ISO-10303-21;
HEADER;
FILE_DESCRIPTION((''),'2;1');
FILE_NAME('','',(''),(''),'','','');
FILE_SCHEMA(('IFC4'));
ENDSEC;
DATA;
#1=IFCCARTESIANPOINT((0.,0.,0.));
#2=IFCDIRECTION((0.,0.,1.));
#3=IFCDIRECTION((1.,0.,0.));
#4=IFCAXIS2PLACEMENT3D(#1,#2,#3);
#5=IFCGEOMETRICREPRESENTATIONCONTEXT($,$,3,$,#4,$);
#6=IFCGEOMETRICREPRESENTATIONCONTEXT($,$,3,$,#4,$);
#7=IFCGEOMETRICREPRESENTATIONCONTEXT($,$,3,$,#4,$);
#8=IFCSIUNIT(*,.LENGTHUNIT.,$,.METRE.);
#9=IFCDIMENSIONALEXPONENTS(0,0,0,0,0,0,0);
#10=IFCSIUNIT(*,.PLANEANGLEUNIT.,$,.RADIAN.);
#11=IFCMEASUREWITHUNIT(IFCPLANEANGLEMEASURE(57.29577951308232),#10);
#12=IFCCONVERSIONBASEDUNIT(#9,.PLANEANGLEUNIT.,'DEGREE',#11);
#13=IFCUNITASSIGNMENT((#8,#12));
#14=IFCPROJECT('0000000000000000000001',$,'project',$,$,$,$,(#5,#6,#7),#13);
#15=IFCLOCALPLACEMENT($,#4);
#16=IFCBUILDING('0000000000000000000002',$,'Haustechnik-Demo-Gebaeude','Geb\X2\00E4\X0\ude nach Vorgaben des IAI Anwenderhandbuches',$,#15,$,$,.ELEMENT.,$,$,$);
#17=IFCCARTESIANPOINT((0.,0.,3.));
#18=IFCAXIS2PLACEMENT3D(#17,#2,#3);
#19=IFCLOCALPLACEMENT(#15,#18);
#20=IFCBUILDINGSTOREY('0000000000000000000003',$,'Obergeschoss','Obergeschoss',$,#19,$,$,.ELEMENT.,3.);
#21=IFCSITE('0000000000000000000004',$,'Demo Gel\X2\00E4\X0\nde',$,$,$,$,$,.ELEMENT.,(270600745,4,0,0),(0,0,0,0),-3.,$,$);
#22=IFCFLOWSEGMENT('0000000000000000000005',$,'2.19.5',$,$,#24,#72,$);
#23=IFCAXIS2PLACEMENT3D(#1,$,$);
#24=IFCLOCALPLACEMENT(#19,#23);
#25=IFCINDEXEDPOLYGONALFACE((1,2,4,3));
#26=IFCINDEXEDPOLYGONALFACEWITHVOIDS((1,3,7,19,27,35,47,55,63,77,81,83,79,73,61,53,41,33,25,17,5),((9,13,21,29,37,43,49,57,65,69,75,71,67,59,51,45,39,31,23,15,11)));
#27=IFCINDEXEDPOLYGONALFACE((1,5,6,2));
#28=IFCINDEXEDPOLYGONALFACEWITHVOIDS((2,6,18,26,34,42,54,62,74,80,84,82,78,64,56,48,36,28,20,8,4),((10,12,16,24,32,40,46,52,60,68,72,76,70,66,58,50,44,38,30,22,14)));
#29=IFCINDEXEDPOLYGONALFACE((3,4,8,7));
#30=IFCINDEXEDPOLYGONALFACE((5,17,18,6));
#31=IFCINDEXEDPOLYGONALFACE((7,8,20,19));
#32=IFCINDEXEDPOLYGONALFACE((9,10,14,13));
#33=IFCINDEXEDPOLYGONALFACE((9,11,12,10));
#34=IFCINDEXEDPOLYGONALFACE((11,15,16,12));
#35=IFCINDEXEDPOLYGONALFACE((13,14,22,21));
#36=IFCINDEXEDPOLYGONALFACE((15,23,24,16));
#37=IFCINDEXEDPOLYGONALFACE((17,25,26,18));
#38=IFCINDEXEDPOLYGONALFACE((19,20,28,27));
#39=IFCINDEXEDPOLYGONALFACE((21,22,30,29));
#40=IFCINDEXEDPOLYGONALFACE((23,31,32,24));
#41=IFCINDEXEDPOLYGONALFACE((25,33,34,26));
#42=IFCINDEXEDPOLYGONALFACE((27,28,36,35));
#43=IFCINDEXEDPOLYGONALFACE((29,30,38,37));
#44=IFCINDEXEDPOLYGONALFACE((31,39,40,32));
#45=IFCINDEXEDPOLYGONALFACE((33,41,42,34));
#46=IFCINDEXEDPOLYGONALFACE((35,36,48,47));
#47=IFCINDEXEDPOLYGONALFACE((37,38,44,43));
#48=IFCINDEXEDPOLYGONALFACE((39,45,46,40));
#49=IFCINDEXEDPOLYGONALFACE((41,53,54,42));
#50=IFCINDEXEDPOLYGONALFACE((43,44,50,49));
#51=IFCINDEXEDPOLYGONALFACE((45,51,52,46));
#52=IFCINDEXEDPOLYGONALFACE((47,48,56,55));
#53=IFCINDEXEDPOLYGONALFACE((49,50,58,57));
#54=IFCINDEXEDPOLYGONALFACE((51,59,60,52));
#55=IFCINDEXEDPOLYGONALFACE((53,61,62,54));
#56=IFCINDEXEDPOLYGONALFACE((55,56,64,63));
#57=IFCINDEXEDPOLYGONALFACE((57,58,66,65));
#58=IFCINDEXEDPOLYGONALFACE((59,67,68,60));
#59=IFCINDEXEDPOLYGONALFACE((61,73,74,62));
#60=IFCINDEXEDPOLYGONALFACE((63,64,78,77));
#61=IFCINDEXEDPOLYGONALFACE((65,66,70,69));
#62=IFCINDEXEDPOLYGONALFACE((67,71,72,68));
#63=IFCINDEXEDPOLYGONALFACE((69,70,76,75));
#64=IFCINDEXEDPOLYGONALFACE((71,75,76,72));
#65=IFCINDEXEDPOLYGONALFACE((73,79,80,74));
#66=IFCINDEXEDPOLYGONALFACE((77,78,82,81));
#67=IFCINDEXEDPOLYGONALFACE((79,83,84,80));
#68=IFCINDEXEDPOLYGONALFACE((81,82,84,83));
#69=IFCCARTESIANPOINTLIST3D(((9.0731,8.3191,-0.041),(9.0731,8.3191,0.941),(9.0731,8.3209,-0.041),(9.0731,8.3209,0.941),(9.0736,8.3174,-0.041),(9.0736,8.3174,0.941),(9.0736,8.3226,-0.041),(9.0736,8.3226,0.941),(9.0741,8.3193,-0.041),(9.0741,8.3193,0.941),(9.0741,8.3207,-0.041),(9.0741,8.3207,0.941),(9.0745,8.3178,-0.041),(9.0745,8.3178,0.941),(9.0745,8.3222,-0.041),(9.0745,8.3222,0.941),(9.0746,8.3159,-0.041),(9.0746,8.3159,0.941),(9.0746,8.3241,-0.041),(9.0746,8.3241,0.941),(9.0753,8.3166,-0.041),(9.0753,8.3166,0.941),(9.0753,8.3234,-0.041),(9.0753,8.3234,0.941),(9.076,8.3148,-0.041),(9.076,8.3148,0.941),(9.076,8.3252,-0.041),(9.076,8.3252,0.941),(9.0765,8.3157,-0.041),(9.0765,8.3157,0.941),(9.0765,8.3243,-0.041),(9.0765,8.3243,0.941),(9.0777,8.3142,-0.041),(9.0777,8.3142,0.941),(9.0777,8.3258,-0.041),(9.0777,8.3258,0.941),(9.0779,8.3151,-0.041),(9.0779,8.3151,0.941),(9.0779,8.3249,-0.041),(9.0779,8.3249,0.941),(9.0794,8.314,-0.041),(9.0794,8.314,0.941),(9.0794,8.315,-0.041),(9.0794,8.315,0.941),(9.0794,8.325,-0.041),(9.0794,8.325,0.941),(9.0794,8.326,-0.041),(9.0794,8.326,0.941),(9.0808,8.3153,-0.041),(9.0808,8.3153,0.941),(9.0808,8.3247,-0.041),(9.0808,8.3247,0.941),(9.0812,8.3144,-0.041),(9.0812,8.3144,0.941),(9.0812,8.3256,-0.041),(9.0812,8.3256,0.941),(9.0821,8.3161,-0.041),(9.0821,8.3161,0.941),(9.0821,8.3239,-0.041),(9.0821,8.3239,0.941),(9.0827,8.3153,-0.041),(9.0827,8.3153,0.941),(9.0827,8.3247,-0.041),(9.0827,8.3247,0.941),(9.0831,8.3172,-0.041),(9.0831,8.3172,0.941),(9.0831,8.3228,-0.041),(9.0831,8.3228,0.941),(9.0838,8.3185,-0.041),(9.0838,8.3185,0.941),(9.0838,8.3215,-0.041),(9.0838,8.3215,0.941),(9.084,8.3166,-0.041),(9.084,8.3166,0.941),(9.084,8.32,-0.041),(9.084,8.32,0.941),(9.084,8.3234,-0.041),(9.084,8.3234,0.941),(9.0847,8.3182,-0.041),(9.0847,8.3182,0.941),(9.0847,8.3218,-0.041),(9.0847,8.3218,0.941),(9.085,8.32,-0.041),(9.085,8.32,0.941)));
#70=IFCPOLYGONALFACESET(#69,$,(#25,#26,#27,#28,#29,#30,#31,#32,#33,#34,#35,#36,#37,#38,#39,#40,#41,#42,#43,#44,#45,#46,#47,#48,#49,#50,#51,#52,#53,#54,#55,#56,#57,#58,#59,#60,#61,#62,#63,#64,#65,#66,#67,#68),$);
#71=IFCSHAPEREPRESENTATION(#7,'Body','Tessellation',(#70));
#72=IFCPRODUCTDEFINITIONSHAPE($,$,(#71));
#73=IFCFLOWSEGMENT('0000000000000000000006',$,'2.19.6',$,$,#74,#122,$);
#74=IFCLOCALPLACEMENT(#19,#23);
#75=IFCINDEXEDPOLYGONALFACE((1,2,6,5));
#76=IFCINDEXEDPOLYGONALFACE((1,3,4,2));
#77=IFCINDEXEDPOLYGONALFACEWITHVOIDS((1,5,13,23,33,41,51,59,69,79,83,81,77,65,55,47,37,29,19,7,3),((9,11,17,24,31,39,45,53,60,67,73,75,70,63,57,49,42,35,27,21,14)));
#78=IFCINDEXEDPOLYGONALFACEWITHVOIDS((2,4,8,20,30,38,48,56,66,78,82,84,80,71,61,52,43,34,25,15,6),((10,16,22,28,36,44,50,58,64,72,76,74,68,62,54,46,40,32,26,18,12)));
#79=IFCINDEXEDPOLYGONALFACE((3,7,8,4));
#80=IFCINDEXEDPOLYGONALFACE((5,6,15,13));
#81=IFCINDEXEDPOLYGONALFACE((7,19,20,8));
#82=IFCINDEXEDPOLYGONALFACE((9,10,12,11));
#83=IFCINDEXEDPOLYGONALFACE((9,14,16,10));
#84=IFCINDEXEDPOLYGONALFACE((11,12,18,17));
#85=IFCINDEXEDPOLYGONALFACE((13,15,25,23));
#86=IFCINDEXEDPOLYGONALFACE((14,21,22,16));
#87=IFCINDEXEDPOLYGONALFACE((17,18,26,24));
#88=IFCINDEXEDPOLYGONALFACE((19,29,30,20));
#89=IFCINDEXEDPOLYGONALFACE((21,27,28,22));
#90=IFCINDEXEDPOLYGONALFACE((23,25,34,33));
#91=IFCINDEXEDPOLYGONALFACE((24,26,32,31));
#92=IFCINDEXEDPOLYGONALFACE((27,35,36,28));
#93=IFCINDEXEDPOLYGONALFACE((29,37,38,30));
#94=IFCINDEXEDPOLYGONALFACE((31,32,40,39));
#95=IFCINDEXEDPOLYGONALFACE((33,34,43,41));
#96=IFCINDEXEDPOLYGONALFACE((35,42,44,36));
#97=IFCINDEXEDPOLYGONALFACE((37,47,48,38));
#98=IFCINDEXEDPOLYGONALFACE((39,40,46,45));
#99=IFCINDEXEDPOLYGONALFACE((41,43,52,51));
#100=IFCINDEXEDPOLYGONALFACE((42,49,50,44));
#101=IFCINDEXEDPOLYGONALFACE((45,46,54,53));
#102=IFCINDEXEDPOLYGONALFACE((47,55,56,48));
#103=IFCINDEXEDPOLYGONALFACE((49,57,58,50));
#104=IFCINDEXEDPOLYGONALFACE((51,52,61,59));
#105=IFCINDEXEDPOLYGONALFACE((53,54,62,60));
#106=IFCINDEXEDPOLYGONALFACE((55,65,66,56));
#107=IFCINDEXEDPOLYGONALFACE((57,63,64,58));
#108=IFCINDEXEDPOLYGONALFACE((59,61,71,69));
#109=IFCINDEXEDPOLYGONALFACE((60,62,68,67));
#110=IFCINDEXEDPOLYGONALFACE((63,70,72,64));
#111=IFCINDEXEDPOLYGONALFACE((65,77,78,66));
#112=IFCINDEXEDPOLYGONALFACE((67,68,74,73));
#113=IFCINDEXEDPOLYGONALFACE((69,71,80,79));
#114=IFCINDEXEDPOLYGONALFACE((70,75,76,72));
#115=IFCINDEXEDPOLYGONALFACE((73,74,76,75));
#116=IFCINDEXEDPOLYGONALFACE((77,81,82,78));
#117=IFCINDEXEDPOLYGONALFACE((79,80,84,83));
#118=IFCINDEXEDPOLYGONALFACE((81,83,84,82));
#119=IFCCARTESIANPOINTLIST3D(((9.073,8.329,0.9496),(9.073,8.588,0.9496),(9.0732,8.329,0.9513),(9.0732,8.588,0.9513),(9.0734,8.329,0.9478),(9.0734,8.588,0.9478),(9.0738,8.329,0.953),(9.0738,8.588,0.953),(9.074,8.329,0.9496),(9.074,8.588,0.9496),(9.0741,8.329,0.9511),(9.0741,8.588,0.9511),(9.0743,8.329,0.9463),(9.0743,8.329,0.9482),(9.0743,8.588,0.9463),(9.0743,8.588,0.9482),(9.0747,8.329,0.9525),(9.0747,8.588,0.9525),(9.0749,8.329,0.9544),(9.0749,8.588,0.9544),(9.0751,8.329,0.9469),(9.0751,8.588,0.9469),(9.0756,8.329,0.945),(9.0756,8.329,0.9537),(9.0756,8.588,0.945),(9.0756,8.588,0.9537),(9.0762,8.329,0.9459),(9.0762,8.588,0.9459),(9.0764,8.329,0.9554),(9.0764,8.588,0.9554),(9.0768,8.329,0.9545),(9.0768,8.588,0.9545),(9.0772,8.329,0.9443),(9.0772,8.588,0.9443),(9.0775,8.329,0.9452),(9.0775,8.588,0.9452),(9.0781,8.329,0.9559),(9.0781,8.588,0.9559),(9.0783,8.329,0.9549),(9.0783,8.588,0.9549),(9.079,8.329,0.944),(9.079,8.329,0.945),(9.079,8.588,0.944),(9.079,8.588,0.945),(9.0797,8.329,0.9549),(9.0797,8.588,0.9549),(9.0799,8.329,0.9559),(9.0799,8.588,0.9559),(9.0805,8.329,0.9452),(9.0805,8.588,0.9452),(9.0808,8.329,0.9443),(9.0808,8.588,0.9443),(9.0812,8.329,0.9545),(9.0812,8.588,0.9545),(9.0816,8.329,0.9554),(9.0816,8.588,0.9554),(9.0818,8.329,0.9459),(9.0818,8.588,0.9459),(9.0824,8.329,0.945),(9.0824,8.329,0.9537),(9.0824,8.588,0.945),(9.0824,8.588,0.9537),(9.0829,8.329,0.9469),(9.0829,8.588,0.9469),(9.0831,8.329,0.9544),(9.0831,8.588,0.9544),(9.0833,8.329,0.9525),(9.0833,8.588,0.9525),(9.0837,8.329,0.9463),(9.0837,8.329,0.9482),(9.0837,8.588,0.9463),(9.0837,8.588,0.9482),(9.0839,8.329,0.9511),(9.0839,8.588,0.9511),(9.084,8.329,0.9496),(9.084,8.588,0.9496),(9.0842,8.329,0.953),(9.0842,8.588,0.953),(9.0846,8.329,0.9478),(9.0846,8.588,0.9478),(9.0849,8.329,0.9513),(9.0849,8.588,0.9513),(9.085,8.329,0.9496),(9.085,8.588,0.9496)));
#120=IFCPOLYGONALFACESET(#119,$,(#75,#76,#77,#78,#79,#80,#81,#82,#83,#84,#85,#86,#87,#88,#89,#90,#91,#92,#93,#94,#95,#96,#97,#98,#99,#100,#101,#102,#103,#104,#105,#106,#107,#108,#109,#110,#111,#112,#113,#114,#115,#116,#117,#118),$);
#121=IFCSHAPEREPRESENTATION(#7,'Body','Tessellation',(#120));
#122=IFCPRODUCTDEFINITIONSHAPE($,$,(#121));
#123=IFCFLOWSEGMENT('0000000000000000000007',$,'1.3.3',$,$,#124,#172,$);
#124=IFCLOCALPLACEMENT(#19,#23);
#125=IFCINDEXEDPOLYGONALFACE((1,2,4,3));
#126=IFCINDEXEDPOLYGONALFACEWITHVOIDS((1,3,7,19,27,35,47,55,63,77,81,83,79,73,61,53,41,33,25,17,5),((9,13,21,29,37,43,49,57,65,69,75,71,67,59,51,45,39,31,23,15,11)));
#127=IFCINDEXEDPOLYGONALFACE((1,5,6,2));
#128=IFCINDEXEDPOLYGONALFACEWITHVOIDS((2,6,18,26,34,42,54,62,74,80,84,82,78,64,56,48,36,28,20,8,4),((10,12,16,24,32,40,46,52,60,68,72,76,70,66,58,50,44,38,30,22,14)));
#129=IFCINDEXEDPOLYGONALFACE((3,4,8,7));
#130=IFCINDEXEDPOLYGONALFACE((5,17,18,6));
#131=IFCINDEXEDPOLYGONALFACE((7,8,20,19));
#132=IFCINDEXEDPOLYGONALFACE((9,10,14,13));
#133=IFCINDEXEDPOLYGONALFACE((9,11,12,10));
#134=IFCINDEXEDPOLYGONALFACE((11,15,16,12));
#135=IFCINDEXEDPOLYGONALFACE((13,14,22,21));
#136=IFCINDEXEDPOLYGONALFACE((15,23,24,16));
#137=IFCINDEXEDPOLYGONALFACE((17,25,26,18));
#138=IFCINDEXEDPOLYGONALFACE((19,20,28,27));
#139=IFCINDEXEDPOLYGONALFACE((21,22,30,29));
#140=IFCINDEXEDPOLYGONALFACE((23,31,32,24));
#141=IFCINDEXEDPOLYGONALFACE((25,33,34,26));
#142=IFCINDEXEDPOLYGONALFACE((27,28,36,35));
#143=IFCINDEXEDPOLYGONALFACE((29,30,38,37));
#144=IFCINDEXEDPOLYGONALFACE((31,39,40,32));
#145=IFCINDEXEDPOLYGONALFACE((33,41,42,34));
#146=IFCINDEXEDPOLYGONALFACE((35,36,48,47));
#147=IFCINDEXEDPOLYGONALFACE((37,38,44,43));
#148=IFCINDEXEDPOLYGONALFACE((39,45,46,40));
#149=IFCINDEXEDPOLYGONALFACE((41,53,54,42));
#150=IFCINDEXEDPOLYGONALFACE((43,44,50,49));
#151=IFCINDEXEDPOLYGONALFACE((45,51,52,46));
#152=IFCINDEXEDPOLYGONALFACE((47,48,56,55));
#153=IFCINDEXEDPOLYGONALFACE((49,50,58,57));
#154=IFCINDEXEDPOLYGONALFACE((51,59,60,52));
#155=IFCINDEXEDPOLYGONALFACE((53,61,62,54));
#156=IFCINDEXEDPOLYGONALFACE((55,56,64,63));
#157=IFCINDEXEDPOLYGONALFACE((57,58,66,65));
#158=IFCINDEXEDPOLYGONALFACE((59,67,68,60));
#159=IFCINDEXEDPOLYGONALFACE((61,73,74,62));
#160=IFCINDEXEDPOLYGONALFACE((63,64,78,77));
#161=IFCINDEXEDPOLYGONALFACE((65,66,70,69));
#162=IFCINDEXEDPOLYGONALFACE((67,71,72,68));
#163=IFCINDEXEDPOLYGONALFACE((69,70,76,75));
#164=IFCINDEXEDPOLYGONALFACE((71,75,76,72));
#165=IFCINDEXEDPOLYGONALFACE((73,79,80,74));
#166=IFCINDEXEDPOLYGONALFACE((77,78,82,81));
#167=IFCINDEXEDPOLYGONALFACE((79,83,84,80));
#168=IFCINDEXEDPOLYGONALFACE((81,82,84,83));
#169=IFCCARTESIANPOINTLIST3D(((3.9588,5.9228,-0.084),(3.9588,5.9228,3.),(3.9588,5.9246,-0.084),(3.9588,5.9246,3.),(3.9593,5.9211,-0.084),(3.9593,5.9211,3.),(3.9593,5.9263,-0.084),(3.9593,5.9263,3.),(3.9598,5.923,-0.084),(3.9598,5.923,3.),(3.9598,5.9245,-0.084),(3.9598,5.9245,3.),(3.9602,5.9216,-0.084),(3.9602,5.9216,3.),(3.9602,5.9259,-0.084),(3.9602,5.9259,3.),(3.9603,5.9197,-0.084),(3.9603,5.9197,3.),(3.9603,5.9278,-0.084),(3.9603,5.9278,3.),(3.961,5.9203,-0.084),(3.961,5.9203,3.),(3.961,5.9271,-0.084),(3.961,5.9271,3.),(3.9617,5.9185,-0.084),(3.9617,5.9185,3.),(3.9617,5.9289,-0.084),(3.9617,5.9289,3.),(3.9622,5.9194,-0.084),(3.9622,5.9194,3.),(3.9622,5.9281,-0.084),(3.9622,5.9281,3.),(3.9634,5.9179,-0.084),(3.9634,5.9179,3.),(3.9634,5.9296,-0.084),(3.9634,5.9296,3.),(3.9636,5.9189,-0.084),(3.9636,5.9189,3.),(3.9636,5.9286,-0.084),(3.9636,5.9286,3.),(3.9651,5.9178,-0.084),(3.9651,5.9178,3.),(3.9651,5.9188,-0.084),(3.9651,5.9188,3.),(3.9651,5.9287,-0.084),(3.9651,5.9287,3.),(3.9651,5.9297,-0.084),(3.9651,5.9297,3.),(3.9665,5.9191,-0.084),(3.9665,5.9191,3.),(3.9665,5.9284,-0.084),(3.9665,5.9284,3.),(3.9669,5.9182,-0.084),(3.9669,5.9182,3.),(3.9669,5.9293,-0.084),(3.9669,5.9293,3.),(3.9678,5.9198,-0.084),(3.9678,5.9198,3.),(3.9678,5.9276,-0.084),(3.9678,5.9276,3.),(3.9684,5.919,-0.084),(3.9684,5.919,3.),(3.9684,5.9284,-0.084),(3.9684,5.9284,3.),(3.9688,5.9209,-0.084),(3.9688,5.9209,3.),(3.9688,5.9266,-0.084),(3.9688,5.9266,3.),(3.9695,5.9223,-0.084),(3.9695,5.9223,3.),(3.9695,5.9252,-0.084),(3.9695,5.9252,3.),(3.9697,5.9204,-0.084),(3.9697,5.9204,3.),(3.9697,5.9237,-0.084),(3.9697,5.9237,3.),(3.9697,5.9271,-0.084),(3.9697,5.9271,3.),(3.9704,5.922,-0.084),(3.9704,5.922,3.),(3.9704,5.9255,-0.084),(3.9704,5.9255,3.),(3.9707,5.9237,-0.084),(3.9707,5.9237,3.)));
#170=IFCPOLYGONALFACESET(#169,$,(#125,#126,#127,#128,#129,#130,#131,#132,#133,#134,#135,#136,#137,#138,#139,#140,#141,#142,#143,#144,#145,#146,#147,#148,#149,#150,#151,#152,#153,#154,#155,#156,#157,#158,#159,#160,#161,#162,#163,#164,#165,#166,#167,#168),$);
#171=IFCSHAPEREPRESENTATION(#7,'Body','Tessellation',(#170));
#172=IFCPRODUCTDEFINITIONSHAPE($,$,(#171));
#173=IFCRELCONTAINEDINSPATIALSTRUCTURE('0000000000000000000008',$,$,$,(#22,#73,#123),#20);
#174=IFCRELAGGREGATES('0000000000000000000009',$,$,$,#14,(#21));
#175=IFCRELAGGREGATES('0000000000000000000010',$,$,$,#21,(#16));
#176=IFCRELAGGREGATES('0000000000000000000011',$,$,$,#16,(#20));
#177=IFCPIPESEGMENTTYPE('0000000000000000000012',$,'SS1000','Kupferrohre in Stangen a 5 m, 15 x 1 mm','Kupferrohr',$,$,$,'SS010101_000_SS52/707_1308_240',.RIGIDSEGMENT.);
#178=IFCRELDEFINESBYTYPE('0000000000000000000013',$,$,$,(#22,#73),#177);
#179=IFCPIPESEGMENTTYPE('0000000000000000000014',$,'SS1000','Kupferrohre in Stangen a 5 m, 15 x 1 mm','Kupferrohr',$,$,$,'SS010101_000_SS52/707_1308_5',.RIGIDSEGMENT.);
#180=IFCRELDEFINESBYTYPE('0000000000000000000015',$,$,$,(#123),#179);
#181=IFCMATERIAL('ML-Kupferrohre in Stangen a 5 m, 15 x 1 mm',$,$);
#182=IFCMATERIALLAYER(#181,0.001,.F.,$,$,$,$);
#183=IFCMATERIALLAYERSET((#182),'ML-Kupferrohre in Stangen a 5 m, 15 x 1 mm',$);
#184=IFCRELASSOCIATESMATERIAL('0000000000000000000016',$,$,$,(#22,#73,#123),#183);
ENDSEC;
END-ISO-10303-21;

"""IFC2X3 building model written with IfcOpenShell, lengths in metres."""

from ifc_helpers import new_model, entity, si_unit, converted_unit, frame, origin_with_axes, origin_2d_with_axis, place, context, project, spatial, hollow_circle, extrude, material, layer, layer_set, layer_usage, type_object, element, save


model = new_model("IFC2X3")

# Units and contexts
context_of_model_1 = context(None, 3, world=origin_with_axes())
context_of_model_2 = context(None, 3, world=origin_with_axes())
context_of_model_3 = context(None, 3, world=origin_with_axes())
ifc_project = project(units=[si_unit("LENGTHUNIT", "METRE"), converted_unit("PLANEANGLEUNIT", "DEGREE", entity("IfcPlaneAngleMeasure", 57.29577951308232), si_unit("PLANEANGLEUNIT", "RADIAN"), dimensions=[0, 0, 0, 0, 0, 0, 0])], contexts=[context_of_model_1, context_of_model_2, context_of_model_3])

# Site, building, storey
site = spatial("IfcSite", under=ifc_project, Name="Demo Gelände", CompositionType="ELEMENT", RefLatitude=(270600745, 4, 0, 0), RefLongitude=(0, 0, 0, 0), RefElevation=-3.0)
building_placement = place(None, origin_with_axes())
building = spatial("IfcBuilding", under=site, at=building_placement, Name="Haustechnik-Demo-Gebaeude", Description="Gebäude nach Vorgaben des IAI Anwenderhandbuches", CompositionType="ELEMENT")
storey_placement = place(building_placement, frame((0.0, 0.0, 3.0), z_axis=(0.0, 0.0, 1.0), x_axis=(1.0, 0.0, 0.0)))
storey = spatial("IfcBuildingStorey", under=building, at=storey_placement, Name="Obergeschoss", Description="Obergeschoss", CompositionType="ELEMENT", Elevation=3.0)

# Flow segments
ifc_material_1 = material(Name="ML-Kupferrohre in Stangen a 5 m, 15 x 1 mm")
ifc_layer_1 = layer(ifc_material_1, 0.001, ventilated=False)
ifc_layer_set_1 = layer_set([ifc_layer_1], Name="ML-Kupferrohre in Stangen a 5 m, 15 x 1 mm")
ifc_layer_usage_1 = layer_usage(ifc_layer_set_1, "AXIS2", "POSITIVE", 0.0)
pipe_segment_type_1 = type_object("IfcPipeSegmentType", Name="SS1000", Description="Kupferrohre in Stangen a 5 m, 15 x 1 mm", ApplicableOccurrence="Kupferrohr", ElementType="SS010101_000_SS52/707_1308_240", PredefinedType="RIGIDSEGMENT")
flow_segment_1_placement = place(storey_placement, frame((9.079, 8.32, -0.041), z_axis=(0.0, 0.0, 1.0), x_axis=(1.0, 0.0, 0.0)))
element("IfcFlowSegment", 1, at=flow_segment_1_placement, inside=storey, type_object=pipe_segment_type_1, material=ifc_layer_usage_1, Name="2.19.5", context=context_of_model_3, shape_type="SweptSolid", body=[
    extrude(hollow_circle(Radius=0.006, WallThickness=0.001, at=origin_2d_with_axis()), origin_with_axes(), (0.0, 0.0, 1.0), 0.982),
])
flow_segment_2_placement = place(storey_placement, frame((9.079, 8.329, 0.95), z_axis=(0.0, 1.0, 0.0), x_axis=(0.0, 0.0, -1.0)))
element("IfcFlowSegment", 2, at=flow_segment_2_placement, inside=storey, type_object=pipe_segment_type_1, material=ifc_layer_usage_1, Name="2.19.6", context=context_of_model_3, shape_type="SweptSolid", body=[
    extrude(hollow_circle(Radius=0.006, WallThickness=0.001, at=origin_2d_with_axis()), origin_with_axes(), (0.0, 0.0, 1.0), 0.259),
])
pipe_segment_type_2 = type_object("IfcPipeSegmentType", Name="SS1000", Description="Kupferrohre in Stangen a 5 m, 15 x 1 mm", ApplicableOccurrence="Kupferrohr", ElementType="SS010101_000_SS52/707_1308_5", PredefinedType="RIGIDSEGMENT")
flow_segment_3_placement = place(storey_placement, frame((3.9647, 5.9237, -0.084), z_axis=(0.0, 0.0, 1.0), x_axis=(1.0, 0.0, 0.0)))
element("IfcFlowSegment", 3, at=flow_segment_3_placement, inside=storey, type_object=pipe_segment_type_2, material=ifc_layer_usage_1, Name="1.3.3", context=context_of_model_3, shape_type="SweptSolid", body=[
    extrude(hollow_circle(Radius=0.006, WallThickness=0.001, at=origin_2d_with_axis()), origin_with_axes(), (0.0, 0.0, 1.0), 3.084),
])

save(model, "model.ifc")
